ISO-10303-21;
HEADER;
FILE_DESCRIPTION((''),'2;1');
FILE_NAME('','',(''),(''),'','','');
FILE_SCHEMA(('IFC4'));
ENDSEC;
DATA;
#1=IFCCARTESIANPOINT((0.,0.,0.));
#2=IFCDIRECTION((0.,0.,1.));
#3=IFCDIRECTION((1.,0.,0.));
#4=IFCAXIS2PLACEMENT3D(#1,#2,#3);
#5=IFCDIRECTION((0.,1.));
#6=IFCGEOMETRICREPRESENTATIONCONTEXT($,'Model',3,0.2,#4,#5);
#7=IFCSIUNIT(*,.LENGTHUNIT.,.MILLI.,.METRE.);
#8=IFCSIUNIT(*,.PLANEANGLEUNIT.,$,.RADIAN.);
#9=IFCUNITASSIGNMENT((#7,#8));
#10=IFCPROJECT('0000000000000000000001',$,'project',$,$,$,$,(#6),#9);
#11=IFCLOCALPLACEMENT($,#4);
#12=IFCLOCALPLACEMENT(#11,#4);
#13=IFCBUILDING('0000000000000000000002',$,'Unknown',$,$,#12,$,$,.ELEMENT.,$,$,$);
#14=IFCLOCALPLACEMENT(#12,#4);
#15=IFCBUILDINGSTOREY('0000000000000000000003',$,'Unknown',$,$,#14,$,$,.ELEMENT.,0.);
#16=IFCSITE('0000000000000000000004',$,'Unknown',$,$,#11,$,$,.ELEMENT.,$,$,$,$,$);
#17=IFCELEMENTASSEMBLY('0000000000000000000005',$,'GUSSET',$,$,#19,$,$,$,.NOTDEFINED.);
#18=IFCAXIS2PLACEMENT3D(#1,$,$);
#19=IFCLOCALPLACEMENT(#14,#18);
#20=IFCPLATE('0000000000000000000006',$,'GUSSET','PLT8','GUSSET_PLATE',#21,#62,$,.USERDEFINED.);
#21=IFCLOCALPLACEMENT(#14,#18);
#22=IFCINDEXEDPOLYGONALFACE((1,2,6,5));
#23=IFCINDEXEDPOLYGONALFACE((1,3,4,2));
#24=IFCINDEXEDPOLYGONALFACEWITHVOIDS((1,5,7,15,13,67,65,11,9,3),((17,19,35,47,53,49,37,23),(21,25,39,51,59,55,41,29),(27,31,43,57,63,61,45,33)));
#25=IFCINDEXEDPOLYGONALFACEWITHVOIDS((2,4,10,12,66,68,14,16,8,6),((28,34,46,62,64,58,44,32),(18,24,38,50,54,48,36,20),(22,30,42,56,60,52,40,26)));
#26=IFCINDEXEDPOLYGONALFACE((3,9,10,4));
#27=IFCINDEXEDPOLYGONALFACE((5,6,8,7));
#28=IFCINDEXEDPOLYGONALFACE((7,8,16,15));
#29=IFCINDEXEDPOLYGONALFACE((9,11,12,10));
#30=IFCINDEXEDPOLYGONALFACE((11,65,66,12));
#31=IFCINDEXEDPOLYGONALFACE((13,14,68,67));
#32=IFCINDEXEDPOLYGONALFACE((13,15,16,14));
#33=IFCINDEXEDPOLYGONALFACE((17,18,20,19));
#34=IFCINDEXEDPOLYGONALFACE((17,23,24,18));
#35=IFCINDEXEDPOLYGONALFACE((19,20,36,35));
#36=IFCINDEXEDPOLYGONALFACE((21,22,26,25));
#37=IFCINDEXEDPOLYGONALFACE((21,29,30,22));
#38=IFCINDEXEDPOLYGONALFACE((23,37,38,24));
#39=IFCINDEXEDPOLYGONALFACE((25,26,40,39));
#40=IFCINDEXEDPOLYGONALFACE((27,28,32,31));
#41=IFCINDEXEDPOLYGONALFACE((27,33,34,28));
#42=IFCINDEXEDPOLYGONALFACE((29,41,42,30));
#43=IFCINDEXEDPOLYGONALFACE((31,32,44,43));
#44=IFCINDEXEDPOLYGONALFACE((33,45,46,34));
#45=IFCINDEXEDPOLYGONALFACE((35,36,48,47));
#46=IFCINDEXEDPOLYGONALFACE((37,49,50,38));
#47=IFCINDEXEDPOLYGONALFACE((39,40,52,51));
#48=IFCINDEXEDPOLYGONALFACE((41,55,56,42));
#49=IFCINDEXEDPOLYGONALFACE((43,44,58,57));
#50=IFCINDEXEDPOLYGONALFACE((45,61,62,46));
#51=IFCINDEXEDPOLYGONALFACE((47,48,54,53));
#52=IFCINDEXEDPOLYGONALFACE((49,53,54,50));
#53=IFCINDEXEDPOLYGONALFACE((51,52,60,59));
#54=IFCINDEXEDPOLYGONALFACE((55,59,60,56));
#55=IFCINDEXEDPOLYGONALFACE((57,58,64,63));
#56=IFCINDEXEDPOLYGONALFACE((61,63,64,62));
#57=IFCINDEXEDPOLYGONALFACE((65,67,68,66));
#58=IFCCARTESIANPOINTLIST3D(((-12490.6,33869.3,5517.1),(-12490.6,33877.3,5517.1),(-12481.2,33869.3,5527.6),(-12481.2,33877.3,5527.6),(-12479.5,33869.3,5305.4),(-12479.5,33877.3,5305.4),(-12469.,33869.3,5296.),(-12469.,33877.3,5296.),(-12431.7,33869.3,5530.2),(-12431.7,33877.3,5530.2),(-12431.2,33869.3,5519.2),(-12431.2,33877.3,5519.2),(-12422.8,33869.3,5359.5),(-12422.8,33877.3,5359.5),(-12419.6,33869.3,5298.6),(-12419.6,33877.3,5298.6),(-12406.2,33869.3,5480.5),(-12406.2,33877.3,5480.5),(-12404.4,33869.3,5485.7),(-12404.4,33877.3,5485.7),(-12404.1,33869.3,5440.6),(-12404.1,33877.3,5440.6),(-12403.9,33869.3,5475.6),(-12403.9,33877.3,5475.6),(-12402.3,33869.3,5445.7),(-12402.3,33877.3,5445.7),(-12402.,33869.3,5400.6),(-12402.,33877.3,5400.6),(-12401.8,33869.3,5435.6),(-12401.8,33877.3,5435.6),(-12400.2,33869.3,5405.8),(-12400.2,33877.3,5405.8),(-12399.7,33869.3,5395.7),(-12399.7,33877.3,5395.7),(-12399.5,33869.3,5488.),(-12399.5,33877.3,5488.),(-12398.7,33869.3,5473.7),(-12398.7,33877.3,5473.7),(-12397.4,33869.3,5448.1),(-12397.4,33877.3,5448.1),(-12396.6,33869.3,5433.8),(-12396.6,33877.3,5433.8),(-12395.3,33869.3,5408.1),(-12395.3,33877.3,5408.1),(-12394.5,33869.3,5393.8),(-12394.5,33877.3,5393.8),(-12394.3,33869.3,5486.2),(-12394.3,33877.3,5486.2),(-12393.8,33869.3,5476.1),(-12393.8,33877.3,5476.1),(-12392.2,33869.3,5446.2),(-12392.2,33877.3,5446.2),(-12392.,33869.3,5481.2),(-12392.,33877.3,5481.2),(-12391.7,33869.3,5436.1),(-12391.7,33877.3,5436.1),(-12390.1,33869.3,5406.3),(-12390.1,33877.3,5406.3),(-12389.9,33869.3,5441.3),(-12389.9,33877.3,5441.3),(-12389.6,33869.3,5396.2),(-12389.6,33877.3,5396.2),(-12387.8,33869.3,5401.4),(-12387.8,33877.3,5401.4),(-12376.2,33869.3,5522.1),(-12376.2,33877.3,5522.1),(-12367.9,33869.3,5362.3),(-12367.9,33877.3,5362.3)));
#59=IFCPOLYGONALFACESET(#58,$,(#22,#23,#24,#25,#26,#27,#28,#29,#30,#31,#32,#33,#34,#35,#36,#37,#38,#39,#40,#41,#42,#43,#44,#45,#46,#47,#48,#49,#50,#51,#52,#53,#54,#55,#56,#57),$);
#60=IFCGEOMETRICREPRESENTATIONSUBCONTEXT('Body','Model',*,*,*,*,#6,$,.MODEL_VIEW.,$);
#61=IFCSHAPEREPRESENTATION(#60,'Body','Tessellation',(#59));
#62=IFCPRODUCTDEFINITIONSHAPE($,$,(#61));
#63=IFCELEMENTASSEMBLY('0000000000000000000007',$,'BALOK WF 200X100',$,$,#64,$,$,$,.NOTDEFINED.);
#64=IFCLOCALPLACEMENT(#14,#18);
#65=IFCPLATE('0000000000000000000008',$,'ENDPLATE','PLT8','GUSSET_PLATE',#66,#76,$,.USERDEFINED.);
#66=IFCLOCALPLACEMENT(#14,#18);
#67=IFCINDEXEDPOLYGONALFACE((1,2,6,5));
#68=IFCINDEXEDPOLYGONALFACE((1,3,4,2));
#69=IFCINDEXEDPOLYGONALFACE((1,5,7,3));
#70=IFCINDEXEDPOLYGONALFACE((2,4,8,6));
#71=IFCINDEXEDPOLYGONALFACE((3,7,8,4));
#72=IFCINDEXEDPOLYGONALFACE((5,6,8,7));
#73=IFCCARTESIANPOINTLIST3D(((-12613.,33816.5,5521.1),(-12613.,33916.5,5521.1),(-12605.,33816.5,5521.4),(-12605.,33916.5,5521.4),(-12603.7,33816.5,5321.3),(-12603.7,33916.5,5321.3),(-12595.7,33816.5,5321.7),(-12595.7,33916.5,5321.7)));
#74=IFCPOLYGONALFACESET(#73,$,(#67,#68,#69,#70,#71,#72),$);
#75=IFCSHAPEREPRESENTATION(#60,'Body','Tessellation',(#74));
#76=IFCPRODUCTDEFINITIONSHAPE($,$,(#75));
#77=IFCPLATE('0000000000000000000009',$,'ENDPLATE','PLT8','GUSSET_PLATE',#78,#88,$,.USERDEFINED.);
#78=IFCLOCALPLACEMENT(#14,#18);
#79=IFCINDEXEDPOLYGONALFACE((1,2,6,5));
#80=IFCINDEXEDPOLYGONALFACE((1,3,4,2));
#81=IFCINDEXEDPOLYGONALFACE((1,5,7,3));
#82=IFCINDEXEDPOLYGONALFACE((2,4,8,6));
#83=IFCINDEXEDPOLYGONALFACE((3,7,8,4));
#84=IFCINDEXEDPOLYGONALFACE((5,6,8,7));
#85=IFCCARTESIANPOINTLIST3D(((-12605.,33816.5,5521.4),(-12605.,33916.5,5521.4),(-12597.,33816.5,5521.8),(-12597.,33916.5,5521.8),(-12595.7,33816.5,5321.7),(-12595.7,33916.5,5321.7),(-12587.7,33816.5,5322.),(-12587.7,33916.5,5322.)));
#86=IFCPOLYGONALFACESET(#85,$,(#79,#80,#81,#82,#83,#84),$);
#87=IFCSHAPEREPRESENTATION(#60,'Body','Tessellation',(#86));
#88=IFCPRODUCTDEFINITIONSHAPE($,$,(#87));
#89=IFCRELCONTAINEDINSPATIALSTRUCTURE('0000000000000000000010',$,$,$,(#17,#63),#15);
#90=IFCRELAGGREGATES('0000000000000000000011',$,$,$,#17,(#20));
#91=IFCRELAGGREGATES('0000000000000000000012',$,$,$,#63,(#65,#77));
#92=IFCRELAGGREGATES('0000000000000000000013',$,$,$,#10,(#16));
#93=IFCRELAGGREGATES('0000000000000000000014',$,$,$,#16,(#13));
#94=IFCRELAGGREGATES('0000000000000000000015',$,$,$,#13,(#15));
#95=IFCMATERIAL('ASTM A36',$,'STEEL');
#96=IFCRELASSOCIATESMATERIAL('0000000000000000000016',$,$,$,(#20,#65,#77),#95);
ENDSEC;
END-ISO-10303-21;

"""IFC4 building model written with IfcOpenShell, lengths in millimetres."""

from ifc_helpers import new_model, si_unit, direction, frame, origin_with_axes, place, context, subcontext, project, spatial, line, indexed_curve, outline, extrude, material, element, aggregate, save


model = new_model("IFC4")

# Units and contexts
model_context = context("Model", 3, precision=0.2, world=origin_with_axes(), true_north=direction((0.0, 1.0)))
body_context = subcontext(model_context, "Body", "Model", "MODEL_VIEW")
ifc_project = project(units=[si_unit("LENGTHUNIT", "METRE", prefix="MILLI"), si_unit("PLANEANGLEUNIT", "RADIAN")], contexts=[model_context])

# Site, building, storey
site_placement = place(None, origin_with_axes())
site = spatial("IfcSite", under=ifc_project, at=site_placement, Name="Unknown", CompositionType="ELEMENT")
building_placement = place(site_placement, origin_with_axes())
building = spatial("IfcBuilding", under=site, at=building_placement, Name="Unknown", CompositionType="ELEMENT")
storey_placement = place(building_placement, origin_with_axes())
storey = spatial("IfcBuildingStorey", under=building, at=storey_placement, Name="Unknown", CompositionType="ELEMENT", Elevation=0.0)

# Shared definitions
ifc_material_1 = material(Name="ASTM A36", Category="STEEL")

# Element assembly, plate, voiding features
assembly_1_placement = place(storey_placement, frame((-12491.1, 31473.3, 5527.1), z_axis=(0.0, 1.0, 0.0), x_axis=(0.99863, 0.0, 0.052336)))
assembly_1 = element("IfcElementAssembly", 1, at=assembly_1_placement, inside=storey, Name="GUSSET", PredefinedType="NOTDEFINED")
plate_1_placement = place(assembly_1_placement, frame((0.0, 0.0, 2400.0), z_axis=(0.0, 0.0, 1.0), x_axis=(1.0, 0.0, 0.0)))
plate_1 = element("IfcPlate", 2, at=plate_1_placement, material=ifc_material_1, Name="GUSSET", Description="PLT8", ObjectType="GUSSET_PLATE", PredefinedType="USERDEFINED", context=body_context, shape_type="SolidModel", body=[
    extrude(outline(indexed_curve([(0.0, 0.0), (59.5, 0.0), (59.5, 11.0), (114.5, 11.0), (114.5, 171.0), (59.5, 171.0), (59.5, 232.0), (0.0, 232.0)], segments=[line(1, 2, 3, 4, 5, 6, 7, 8, 1)])), frame((0.0, 0.0, 4.0), z_axis=(0.0, 0.0, 1.0), x_axis=(1.0, 0.0, 0.0)), (0.0, 0.0, -1.0), 8.0),
])
voiding_feature_1_placement = place(plate_1_placement, origin_with_axes())
element("IfcVoidingFeature", 3, at=voiding_feature_1_placement, cuts=plate_1, Name="SLAB", PredefinedType="HOLE", context=body_context, shape_type="SolidModel", body=[
    extrude(outline(indexed_curve([(0.0, 0.0), (10.0, 0.0), (0.0, 10.0)], segments=[line(1, 2, 3, 1)])), frame((0.0, 0.0, 4.0), z_axis=(0.0, 0.0, 1.0), x_axis=(1.0, 0.0, 0.0)), (0.0, 0.0, -1.0), 8.0),
])
voiding_feature_2_placement = place(plate_1_placement, frame((0.0, 222.0, 0.0), z_axis=(0.0, 0.0, 1.0), x_axis=(0.707107, 0.707107, 0.0)))
element("IfcVoidingFeature", 4, at=voiding_feature_2_placement, cuts=plate_1, Name="SLAB", PredefinedType="HOLE", context=body_context, shape_type="SolidModel", body=[
    extrude(outline(indexed_curve([(0.0, 0.0), (14.1, 0.0), (7.1, 7.1)], segments=[line(1, 2, 3, 1)])), frame((0.0, 0.0, 4.0), z_axis=(0.0, 0.0, 1.0), x_axis=(1.0, 0.0, 0.0)), (0.0, 0.0, -1.0), 8.0),
])
voiding_feature_3_placement = place(plate_1_placement, frame((89.5, 91.0, -4.5), z_axis=(-1.0, 0.0, 0.0), x_axis=(0.0, 0.0, 1.0)))
element("IfcVoidingFeature", 5, at=voiding_feature_3_placement, cuts=plate_1, Name="BEAM", PredefinedType="HOLE", context=body_context, shape_type="SolidModel", body=[
    extrude(outline(indexed_curve([(7.1, 0.0), (5.1, 5.1), (0.0, 7.1), (-5.1, 5.1), (-7.1, 0.0), (-5.1, -5.1), (0.0, -7.1), (5.1, -5.1)], segments=[line(1, 2, 3, 4, 5, 6, 7, 8, 1)])), frame((0.0, 0.0, 0.0), z_axis=(-1.0, 0.0, 0.0), x_axis=(0.0, 0.0, 1.0)), (0.0, 0.0, -1.0), 9.0),
])
voiding_feature_4_placement = place(plate_1_placement, frame((89.5, 131.0, -4.5), z_axis=(-1.0, 0.0, 0.0), x_axis=(0.0, 0.0, 1.0)))
element("IfcVoidingFeature", 6, at=voiding_feature_4_placement, cuts=plate_1, Name="BEAM", PredefinedType="HOLE", context=body_context, shape_type="SolidModel", body=[
    extrude(outline(indexed_curve([(7.1, 0.0), (5.1, 5.1), (0.0, 7.1), (-5.1, 5.1), (-7.1, 0.0), (-5.1, -5.1), (0.0, -7.1), (5.1, -5.1)], segments=[line(1, 2, 3, 4, 5, 6, 7, 8, 1)])), frame((0.0, 0.0, 0.0), z_axis=(-1.0, 0.0, 0.0), x_axis=(0.0, 0.0, 1.0)), (0.0, 0.0, -1.0), 9.0),
])
voiding_feature_5_placement = place(plate_1_placement, frame((89.5, 51.0, -4.5), z_axis=(-1.0, 0.0, 0.0), x_axis=(0.0, 0.0, 1.0)))
element("IfcVoidingFeature", 7, at=voiding_feature_5_placement, cuts=plate_1, Name="BEAM", PredefinedType="HOLE", context=body_context, shape_type="SolidModel", body=[
    extrude(outline(indexed_curve([(7.1, 0.0), (5.1, 5.1), (0.0, 7.1), (-5.1, 5.1), (-7.1, 0.0), (-5.1, -5.1), (0.0, -7.1), (5.1, -5.1)], segments=[line(1, 2, 3, 4, 5, 6, 7, 8, 1)])), frame((0.0, 0.0, 0.0), z_axis=(-1.0, 0.0, 0.0), x_axis=(0.0, 0.0, 1.0)), (0.0, 0.0, -1.0), 9.0),
])
aggregate(assembly_1, [plate_1])

# Element assembly, plates
assembly_2_placement = place(storey_placement, frame((-12608.3, 33866.5, 5421.2), z_axis=(0.0, 1.0, 0.0), x_axis=(-0.998912, 0.0, -0.046636)))
assembly_2 = element("IfcElementAssembly", 8, at=assembly_2_placement, inside=storey, Name="BALOK WF 200X100", PredefinedType="NOTDEFINED")
plate_2_placement = place(assembly_2_placement, frame((-4.0, 100.0, 50.0), z_axis=(-1.0, 0.0, 0.0), x_axis=(0.0, 0.0, -1.0)))
plate_2 = element("IfcPlate", 9, at=plate_2_placement, material=ifc_material_1, Name="ENDPLATE", Description="PLT8", ObjectType="GUSSET_PLATE", PredefinedType="USERDEFINED", context=body_context, shape_type="SolidModel", body=[
    extrude(outline(indexed_curve([(0.0, 0.0), (100.0, 0.0), (100.0, 200.0), (0.0, 200.0)], segments=[line(1, 2, 3, 4, 1)])), frame((0.0, 0.0, 4.0), z_axis=(0.0, 0.0, 1.0), x_axis=(1.0, 0.0, 0.0)), (0.0, 0.0, -1.0), 8.0),
])
plate_3_placement = place(assembly_2_placement, frame((-12.0, 100.0, 50.0), z_axis=(-1.0, 0.0, 0.0), x_axis=(0.0, 0.0, -1.0)))
plate_3 = element("IfcPlate", 10, at=plate_3_placement, material=ifc_material_1, Name="ENDPLATE", Description="PLT8", ObjectType="GUSSET_PLATE", PredefinedType="USERDEFINED", context=body_context, shape_type="SolidModel", body=[
    extrude(outline(indexed_curve([(0.0, 0.0), (100.0, 0.0), (100.0, 200.0), (0.0, 200.0)], segments=[line(1, 2, 3, 4, 1)])), frame((0.0, 0.0, 4.0), z_axis=(0.0, 0.0, 1.0), x_axis=(1.0, 0.0, 0.0)), (0.0, 0.0, -1.0), 8.0),
])

aggregate(assembly_2, [plate_2, plate_3])

save(model, "model.ifc")
